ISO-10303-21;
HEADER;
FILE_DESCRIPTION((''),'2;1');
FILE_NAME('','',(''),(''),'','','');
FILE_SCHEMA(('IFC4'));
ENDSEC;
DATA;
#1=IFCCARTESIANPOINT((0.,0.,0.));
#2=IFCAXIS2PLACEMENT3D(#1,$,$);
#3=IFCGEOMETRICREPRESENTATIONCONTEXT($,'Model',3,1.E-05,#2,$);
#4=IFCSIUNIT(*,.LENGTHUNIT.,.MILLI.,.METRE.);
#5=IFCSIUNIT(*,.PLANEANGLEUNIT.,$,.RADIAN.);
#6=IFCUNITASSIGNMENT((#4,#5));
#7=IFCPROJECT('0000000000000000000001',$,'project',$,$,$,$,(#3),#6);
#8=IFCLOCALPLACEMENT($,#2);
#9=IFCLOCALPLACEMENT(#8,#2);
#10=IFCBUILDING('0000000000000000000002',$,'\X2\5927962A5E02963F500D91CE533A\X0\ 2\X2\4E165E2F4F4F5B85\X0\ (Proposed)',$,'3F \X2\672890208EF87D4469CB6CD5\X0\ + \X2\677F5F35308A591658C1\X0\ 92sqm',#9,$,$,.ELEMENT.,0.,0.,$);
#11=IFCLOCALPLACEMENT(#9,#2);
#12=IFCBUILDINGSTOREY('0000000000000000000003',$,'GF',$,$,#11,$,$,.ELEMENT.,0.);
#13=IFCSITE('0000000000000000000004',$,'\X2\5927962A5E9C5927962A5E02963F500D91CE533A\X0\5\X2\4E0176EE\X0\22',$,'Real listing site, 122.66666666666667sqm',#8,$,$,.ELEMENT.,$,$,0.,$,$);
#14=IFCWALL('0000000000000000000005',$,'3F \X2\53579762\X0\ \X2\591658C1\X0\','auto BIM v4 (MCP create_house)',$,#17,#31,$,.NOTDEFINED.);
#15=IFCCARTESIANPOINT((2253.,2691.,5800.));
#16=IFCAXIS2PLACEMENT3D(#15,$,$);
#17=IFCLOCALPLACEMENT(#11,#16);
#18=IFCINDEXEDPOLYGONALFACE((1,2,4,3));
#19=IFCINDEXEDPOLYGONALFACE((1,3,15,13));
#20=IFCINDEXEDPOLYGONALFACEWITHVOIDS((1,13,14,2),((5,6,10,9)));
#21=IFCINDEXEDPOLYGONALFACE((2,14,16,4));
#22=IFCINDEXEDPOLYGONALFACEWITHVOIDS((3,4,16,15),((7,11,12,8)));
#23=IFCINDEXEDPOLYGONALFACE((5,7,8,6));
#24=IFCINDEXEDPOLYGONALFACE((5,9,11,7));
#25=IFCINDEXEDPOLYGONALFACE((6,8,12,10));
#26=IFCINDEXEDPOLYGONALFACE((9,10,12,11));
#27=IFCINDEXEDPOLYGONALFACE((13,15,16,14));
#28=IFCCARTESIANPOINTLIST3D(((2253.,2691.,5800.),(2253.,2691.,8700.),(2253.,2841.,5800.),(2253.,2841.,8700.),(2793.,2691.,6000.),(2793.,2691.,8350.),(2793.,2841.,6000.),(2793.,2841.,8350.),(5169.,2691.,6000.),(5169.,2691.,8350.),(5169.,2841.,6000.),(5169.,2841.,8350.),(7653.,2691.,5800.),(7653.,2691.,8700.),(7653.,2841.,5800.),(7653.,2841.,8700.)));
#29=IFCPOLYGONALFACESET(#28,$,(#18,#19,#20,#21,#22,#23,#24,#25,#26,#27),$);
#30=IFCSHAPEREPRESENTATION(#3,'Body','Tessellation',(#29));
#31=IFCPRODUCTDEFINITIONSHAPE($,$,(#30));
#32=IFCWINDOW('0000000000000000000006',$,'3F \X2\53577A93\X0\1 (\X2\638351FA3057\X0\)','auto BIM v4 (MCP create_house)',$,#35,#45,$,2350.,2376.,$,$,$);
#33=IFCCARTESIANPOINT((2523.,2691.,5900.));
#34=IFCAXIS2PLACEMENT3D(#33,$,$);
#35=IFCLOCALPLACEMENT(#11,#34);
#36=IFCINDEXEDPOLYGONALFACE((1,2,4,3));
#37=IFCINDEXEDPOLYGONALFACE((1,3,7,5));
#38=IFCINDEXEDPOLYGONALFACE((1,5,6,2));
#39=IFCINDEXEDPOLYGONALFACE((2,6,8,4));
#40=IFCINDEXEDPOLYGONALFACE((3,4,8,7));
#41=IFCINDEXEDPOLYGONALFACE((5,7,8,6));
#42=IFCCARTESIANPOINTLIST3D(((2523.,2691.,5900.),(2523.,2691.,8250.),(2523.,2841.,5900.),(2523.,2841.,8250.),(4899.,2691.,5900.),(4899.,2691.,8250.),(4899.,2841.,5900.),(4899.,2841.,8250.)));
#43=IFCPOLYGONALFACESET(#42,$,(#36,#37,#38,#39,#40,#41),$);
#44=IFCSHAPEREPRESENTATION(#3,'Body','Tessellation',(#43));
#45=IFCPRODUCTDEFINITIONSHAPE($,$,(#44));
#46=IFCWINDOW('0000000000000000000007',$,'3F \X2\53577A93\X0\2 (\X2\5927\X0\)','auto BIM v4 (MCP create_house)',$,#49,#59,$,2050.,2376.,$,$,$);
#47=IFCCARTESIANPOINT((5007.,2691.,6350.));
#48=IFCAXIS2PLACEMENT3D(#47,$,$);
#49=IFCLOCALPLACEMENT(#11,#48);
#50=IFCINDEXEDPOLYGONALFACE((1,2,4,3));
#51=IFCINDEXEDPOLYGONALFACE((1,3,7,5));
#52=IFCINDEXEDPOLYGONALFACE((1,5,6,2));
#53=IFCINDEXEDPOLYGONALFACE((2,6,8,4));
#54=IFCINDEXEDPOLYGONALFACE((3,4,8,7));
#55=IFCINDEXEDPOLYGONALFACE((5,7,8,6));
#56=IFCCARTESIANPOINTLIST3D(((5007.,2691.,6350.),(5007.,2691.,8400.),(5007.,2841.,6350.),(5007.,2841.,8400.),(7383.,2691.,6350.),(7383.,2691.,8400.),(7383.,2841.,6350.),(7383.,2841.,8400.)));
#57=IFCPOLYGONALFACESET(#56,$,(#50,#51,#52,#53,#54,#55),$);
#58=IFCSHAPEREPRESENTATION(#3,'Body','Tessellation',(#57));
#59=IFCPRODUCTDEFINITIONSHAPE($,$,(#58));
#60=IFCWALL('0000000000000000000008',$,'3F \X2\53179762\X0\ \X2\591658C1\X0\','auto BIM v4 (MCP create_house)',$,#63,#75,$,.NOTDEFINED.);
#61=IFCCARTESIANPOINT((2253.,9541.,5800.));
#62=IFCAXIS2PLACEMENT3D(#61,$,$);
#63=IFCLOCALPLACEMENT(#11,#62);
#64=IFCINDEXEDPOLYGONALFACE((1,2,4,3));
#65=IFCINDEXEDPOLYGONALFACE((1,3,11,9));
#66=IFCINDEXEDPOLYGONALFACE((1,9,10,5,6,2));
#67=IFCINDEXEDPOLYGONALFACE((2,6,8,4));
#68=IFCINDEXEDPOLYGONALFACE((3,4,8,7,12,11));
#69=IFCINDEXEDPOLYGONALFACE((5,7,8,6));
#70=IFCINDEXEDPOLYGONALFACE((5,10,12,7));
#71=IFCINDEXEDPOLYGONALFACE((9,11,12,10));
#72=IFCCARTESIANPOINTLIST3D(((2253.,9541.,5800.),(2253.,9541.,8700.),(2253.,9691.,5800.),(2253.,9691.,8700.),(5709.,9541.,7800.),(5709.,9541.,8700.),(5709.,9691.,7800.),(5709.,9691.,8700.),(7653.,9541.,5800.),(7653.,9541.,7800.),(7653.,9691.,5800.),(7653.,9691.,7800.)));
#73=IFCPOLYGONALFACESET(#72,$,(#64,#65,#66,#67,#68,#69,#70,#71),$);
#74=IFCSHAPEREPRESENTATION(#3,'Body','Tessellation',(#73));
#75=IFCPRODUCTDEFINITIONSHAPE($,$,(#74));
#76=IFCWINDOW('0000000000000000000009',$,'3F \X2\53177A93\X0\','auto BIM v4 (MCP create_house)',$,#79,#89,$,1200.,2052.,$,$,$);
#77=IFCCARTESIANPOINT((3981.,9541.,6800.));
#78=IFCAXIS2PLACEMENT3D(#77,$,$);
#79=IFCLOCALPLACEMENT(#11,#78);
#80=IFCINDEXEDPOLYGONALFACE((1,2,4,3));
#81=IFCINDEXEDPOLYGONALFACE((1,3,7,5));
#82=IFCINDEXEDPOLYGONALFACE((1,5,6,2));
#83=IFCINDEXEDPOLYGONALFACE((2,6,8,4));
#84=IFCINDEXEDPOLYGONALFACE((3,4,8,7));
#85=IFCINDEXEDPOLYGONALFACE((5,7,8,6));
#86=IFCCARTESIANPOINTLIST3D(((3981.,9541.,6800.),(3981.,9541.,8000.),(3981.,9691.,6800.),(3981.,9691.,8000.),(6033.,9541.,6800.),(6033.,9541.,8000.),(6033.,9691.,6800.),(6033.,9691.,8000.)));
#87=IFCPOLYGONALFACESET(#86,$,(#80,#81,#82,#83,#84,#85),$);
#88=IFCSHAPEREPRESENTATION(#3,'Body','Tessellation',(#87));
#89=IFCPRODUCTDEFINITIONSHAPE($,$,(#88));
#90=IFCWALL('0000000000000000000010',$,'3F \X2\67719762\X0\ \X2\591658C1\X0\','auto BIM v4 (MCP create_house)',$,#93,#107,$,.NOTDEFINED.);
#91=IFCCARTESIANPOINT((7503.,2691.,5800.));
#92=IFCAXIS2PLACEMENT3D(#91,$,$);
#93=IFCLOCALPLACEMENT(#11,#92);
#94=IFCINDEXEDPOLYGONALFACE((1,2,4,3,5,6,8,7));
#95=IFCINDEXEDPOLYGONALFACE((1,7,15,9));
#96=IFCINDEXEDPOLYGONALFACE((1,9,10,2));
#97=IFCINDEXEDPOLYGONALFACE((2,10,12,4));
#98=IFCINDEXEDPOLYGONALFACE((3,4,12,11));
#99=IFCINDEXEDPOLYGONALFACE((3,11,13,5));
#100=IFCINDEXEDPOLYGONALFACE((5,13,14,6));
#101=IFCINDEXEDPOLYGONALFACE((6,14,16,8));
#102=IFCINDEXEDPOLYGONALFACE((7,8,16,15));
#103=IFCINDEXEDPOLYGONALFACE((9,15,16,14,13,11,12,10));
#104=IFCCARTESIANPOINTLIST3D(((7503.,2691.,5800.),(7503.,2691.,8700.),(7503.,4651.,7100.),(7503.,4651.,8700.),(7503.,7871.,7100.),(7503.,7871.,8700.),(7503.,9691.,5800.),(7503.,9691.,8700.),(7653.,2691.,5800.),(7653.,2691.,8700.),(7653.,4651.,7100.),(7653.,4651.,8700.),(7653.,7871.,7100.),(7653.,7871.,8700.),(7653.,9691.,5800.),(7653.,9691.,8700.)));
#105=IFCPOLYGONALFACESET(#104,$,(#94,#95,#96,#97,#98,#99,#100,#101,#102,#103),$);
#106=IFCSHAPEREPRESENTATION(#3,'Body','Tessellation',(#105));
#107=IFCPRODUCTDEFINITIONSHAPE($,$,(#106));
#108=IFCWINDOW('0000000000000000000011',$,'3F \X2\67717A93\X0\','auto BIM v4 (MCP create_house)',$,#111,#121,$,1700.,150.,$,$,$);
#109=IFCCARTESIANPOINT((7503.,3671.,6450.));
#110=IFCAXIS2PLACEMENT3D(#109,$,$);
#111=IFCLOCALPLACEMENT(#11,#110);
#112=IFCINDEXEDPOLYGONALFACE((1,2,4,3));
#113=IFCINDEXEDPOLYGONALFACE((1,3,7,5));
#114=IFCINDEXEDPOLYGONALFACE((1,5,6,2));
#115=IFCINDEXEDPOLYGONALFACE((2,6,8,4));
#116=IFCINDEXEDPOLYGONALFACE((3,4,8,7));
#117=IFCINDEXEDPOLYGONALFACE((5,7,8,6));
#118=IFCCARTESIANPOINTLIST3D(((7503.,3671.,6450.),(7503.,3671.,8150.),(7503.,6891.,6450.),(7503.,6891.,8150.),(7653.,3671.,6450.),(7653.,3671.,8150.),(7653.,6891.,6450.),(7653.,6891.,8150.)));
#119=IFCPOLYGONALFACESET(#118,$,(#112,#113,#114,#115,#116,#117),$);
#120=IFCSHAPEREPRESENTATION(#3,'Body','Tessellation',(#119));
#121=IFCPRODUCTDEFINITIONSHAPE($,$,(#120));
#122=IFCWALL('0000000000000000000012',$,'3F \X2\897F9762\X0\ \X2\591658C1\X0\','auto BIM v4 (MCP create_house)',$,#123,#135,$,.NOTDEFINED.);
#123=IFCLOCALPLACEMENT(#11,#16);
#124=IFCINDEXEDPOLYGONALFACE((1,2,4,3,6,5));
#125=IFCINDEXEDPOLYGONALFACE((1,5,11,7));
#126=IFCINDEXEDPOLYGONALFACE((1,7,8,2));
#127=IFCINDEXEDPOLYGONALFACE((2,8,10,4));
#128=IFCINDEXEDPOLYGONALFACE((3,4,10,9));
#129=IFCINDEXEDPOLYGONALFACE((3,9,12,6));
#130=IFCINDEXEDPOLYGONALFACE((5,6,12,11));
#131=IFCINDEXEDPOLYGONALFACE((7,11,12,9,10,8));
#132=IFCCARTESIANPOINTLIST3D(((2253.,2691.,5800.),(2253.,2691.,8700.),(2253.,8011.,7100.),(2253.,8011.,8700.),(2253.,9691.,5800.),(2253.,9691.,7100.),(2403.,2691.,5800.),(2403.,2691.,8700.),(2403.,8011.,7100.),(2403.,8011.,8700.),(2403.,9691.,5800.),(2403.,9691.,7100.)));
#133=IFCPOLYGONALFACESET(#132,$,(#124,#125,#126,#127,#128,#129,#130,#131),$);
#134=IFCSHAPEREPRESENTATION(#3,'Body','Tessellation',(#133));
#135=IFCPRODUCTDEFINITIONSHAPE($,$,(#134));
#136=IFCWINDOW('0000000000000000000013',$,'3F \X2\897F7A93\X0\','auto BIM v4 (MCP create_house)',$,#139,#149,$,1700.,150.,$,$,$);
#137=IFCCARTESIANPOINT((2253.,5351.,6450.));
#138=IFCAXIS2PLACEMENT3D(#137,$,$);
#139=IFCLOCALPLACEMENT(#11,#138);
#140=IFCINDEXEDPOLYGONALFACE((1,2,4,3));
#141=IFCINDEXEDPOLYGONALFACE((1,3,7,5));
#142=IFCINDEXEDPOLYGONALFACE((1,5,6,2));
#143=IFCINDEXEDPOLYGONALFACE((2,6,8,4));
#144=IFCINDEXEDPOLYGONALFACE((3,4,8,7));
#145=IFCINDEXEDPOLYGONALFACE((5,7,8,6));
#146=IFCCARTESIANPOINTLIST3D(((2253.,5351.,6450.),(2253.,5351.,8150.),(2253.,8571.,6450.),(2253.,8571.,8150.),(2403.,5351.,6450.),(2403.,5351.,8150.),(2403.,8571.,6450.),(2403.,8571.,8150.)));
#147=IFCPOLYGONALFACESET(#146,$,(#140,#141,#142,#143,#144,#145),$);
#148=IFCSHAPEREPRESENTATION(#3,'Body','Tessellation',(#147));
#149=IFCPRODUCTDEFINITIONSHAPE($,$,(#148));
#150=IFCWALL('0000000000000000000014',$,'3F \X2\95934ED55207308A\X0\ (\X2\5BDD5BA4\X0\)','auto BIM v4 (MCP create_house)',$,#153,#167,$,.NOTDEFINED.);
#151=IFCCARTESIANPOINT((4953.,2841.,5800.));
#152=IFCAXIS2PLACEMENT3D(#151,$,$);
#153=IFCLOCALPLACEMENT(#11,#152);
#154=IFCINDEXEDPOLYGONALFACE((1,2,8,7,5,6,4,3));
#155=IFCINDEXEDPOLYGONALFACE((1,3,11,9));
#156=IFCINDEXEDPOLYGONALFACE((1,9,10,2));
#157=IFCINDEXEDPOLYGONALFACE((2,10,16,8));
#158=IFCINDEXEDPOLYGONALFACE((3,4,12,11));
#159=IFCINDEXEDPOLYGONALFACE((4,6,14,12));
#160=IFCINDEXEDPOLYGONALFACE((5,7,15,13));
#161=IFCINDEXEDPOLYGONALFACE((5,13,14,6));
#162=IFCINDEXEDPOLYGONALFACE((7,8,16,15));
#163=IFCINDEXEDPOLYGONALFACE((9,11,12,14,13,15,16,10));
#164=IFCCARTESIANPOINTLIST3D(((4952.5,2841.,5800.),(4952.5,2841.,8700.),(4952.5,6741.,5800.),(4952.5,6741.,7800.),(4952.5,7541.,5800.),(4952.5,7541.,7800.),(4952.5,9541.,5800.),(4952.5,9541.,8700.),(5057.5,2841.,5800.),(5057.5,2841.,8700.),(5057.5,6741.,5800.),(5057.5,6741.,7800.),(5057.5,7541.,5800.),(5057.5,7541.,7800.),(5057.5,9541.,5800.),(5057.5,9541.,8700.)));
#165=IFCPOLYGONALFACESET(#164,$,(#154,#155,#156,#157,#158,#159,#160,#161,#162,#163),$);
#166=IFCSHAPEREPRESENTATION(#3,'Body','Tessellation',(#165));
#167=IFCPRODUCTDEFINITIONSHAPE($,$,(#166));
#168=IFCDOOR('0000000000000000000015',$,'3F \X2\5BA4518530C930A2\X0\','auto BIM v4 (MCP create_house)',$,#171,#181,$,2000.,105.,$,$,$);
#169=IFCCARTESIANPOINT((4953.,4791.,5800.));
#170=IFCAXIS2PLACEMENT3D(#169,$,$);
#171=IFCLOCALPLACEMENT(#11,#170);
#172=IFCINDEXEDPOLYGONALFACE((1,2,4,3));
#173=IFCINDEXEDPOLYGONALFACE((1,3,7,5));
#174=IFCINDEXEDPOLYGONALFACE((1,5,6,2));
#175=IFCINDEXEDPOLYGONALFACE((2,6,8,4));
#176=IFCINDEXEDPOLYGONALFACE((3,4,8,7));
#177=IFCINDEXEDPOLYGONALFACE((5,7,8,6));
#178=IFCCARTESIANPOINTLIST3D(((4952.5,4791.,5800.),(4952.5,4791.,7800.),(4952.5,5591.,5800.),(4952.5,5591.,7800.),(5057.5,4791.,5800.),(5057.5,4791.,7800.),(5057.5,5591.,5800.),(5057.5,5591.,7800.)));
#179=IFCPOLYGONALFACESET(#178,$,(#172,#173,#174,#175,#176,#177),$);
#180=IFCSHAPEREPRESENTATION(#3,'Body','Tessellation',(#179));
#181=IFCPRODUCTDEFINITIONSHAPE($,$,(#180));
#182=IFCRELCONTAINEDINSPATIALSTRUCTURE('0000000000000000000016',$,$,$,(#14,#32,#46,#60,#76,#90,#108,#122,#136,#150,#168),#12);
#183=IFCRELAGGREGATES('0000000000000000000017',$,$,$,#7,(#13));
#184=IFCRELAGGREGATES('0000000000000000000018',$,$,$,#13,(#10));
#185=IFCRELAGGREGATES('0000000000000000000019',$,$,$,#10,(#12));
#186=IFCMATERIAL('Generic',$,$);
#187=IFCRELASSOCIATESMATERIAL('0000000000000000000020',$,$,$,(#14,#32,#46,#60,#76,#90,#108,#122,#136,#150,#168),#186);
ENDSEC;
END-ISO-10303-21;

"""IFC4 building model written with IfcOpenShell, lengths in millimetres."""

from ifc_helpers import new_model, si_unit, frame, frame_2d, origin, place, context, project, spatial, rectangle, extrude, material, element, fill, save


model = new_model("IFC4")

# Units and contexts
model_context = context("Model", 3, precision=1e-05, world=origin())
ifc_project = project(units=[si_unit("LENGTHUNIT", "METRE", prefix="MILLI"), si_unit("PLANEANGLEUNIT", "RADIAN")], contexts=[model_context])

# Site, building, storey
site_placement = place(None, origin())
site = spatial("IfcSite", under=ifc_project, at=site_placement, Name="大阪府大阪市阿倍野区5丁目22", ObjectType="Real listing site, 122.66666666666667sqm", CompositionType="ELEMENT", RefElevation=0.0)
building_placement = place(site_placement, origin())
building = spatial("IfcBuilding", under=site, at=building_placement, Name="大阪市阿倍野区 2世帯住宅 (Proposed)", ObjectType="3F 木造軸組構法 + 板張り外壁 92sqm", CompositionType="ELEMENT", ElevationOfRefHeight=0.0, ElevationOfTerrain=0.0)
storey_placement = place(building_placement, origin())
storey = spatial("IfcBuildingStorey", under=building, at=storey_placement, Name="GF", CompositionType="ELEMENT", Elevation=0.0)

# Shared definitions
ifc_material = material(Name="Generic")

# Wall, openings, windows
wall_1_placement = place(storey_placement, frame((2253.0, 2691.0, 5800.0)))
wall_1 = element("IfcWall", 1, at=wall_1_placement, inside=storey, material=ifc_material, Name="3F 南面 外壁", Description="auto BIM v4 (MCP create_house)", PredefinedType="NOTDEFINED", context=model_context, shape_type="SweptSolid", body=[
    extrude(rectangle(XDim=5400.0, YDim=150.0, at=frame_2d((2700.0, 75.0))), frame((2253.0, 2691.0, 5800.0)), (0.0, 0.0, 1.0), 2900.0),
])
opening_1_placement = place(storey_placement, frame((2523.0, 2691.0, 5900.0)))
opening_1 = element("IfcOpeningElement", 2, at=opening_1_placement, cuts=wall_1, PredefinedType="NOTDEFINED", context=model_context, shape_type="SweptSolid", body=[
    extrude(rectangle(XDim=2376.0, YDim=150.0, at=frame_2d((1188.0, 75.0))), frame((2523.0, 2691.0, 5900.0)), (0.0, 0.0, 1.0), 2350.0),
])
opening_2_placement = place(storey_placement, frame((5007.0, 2691.0, 6350.0)))
opening_2 = element("IfcOpeningElement", 3, at=opening_2_placement, cuts=wall_1, PredefinedType="NOTDEFINED", context=model_context, shape_type="SweptSolid", body=[
    extrude(rectangle(XDim=2376.0, YDim=150.0, at=frame_2d((1188.0, 75.0))), frame((5007.0, 2691.0, 6350.0)), (0.0, 0.0, 1.0), 2050.0),
])
window_1_placement = place(storey_placement, frame((2523.0, 2691.0, 5900.0)))
window_1 = element("IfcWindow", 4, at=window_1_placement, inside=storey, material=ifc_material, Name="3F 南窓1 (掃出し)", Description="auto BIM v4 (MCP create_house)", OverallHeight=2350.0, OverallWidth=2376.0, context=model_context, shape_type="SweptSolid", body=[
    extrude(rectangle(XDim=2376.0, YDim=150.0, at=frame_2d((1188.0, 75.0))), frame((2523.0, 2691.0, 5900.0)), (0.0, 0.0, 1.0), 2350.0),
])
fill(opening_1, window_1)
window_2_placement = place(storey_placement, frame((5007.0, 2691.0, 6350.0)))
window_2 = element("IfcWindow", 5, at=window_2_placement, inside=storey, material=ifc_material, Name="3F 南窓2 (大)", Description="auto BIM v4 (MCP create_house)", OverallHeight=2050.0, OverallWidth=2376.0, context=model_context, shape_type="SweptSolid", body=[
    extrude(rectangle(XDim=2376.0, YDim=150.0, at=frame_2d((1188.0, 75.0))), frame((5007.0, 2691.0, 6350.0)), (0.0, 0.0, 1.0), 2050.0),
])
fill(opening_2, window_2)

# Walls, openings, windows
wall_2_placement = place(storey_placement, frame((2253.0, 9541.0, 5800.0)))
wall_2 = element("IfcWall", 6, at=wall_2_placement, inside=storey, material=ifc_material, Name="3F 北面 外壁", Description="auto BIM v4 (MCP create_house)", PredefinedType="NOTDEFINED", context=model_context, shape_type="SweptSolid", body=[
    extrude(rectangle(XDim=5400.0, YDim=150.0, at=frame_2d((2700.0, 75.0))), frame((2253.0, 9541.0, 5800.0)), (0.0, 0.0, 1.0), 2900.0),
])
opening_3_placement = place(storey_placement, frame((3981.0, 9541.0, 6800.0)))
opening_3 = element("IfcOpeningElement", 7, at=opening_3_placement, cuts=wall_2, PredefinedType="NOTDEFINED", context=model_context, shape_type="SweptSolid", body=[
    extrude(rectangle(XDim=2052.0, YDim=150.0, at=frame_2d((1026.0, 75.0))), frame((3981.0, 9541.0, 6800.0)), (0.0, 0.0, 1.0), 1200.0),
])
window_3_placement = place(storey_placement, frame((3981.0, 9541.0, 6800.0)))
window_3 = element("IfcWindow", 8, at=window_3_placement, inside=storey, material=ifc_material, Name="3F 北窓", Description="auto BIM v4 (MCP create_house)", OverallHeight=1200.0, OverallWidth=2052.0, context=model_context, shape_type="SweptSolid", body=[
    extrude(rectangle(XDim=2052.0, YDim=150.0, at=frame_2d((1026.0, 75.0))), frame((3981.0, 9541.0, 6800.0)), (0.0, 0.0, 1.0), 1200.0),
])
fill(opening_3, window_3)
wall_3_placement = place(storey_placement, frame((7503.0, 2691.0, 5800.0)))
wall_3 = element("IfcWall", 9, at=wall_3_placement, inside=storey, material=ifc_material, Name="3F 東面 外壁", Description="auto BIM v4 (MCP create_house)", PredefinedType="NOTDEFINED", context=model_context, shape_type="SweptSolid", body=[
    extrude(rectangle(XDim=150.0, YDim=7000.0, at=frame_2d((75.0, 3500.0))), frame((7503.0, 2691.0, 5800.0)), (0.0, 0.0, 1.0), 2900.0),
])
opening_4_placement = place(storey_placement, frame((7503.0, 3671.0, 6450.0)))
opening_4 = element("IfcOpeningElement", 10, at=opening_4_placement, cuts=wall_3, PredefinedType="NOTDEFINED", context=model_context, shape_type="SweptSolid", body=[
    extrude(rectangle(XDim=150.0, YDim=3220.0, at=frame_2d((75.0, 1610.0))), frame((7503.0, 3671.0, 6450.0)), (0.0, 0.0, 1.0), 1700.0),
])
window_4_placement = place(storey_placement, frame((7503.0, 3671.0, 6450.0)))
window_4 = element("IfcWindow", 11, at=window_4_placement, inside=storey, material=ifc_material, Name="3F 東窓", Description="auto BIM v4 (MCP create_house)", OverallHeight=1700.0, OverallWidth=150.0, context=model_context, shape_type="SweptSolid", body=[
    extrude(rectangle(XDim=150.0, YDim=3220.0, at=frame_2d((75.0, 1610.0))), frame((7503.0, 3671.0, 6450.0)), (0.0, 0.0, 1.0), 1700.0),
])
fill(opening_4, window_4)
wall_4_placement = place(storey_placement, frame((2253.0, 2691.0, 5800.0)))
wall_4 = element("IfcWall", 12, at=wall_4_placement, inside=storey, material=ifc_material, Name="3F 西面 外壁", Description="auto BIM v4 (MCP create_house)", PredefinedType="NOTDEFINED", context=model_context, shape_type="SweptSolid", body=[
    extrude(rectangle(XDim=150.0, YDim=7000.0, at=frame_2d((75.0, 3500.0))), frame((2253.0, 2691.0, 5800.0)), (0.0, 0.0, 1.0), 2900.0),
])
opening_5_placement = place(storey_placement, frame((2253.0, 5351.0, 6450.0)))
opening_5 = element("IfcOpeningElement", 13, at=opening_5_placement, cuts=wall_4, PredefinedType="NOTDEFINED", context=model_context, shape_type="SweptSolid", body=[
    extrude(rectangle(XDim=150.0, YDim=3220.0, at=frame_2d((75.0, 1610.0))), frame((2253.0, 5351.0, 6450.0)), (0.0, 0.0, 1.0), 1700.0),
])
window_5_placement = place(storey_placement, frame((2253.0, 5351.0, 6450.0)))
window_5 = element("IfcWindow", 14, at=window_5_placement, inside=storey, material=ifc_material, Name="3F 西窓", Description="auto BIM v4 (MCP create_house)", OverallHeight=1700.0, OverallWidth=150.0, context=model_context, shape_type="SweptSolid", body=[
    extrude(rectangle(XDim=150.0, YDim=3220.0, at=frame_2d((75.0, 1610.0))), frame((2253.0, 5351.0, 6450.0)), (0.0, 0.0, 1.0), 1700.0),
])
fill(opening_5, window_5)

# Wall, opening, door
wall_5_placement = place(storey_placement, frame((4953.0, 2841.0, 5800.0)))
wall_5 = element("IfcWall", 15, at=wall_5_placement, inside=storey, material=ifc_material, Name="3F 間仕切り (寝室)", Description="auto BIM v4 (MCP create_house)", PredefinedType="NOTDEFINED", context=model_context, shape_type="SweptSolid", body=[
    extrude(rectangle(XDim=105.0, YDim=6700.0, at=frame_2d((52.0, 3350.0))), frame((4953.0, 2841.0, 5800.0)), (0.0, 0.0, 1.0), 2900.0),
])
opening_6_placement = place(storey_placement, frame((4953.0, 4791.0, 5800.0)))
opening_6 = element("IfcOpeningElement", 16, at=opening_6_placement, cuts=wall_5, PredefinedType="NOTDEFINED", context=model_context, shape_type="SweptSolid", body=[
    extrude(rectangle(XDim=105.0, YDim=800.0, at=frame_2d((52.0, 400.0))), frame((4953.0, 4791.0, 5800.0)), (0.0, 0.0, 1.0), 2000.0),
])
door_1_placement = place(storey_placement, frame((4953.0, 4791.0, 5800.0)))
door_1 = element("IfcDoor", 17, at=door_1_placement, inside=storey, material=ifc_material, Name="3F 室内ドア", Description="auto BIM v4 (MCP create_house)", OverallHeight=2000.0, OverallWidth=105.0, context=model_context, shape_type="SweptSolid", body=[
    extrude(rectangle(XDim=105.0, YDim=800.0, at=frame_2d((52.0, 400.0))), frame((4953.0, 4791.0, 5800.0)), (0.0, 0.0, 1.0), 2000.0),
])
fill(opening_6, door_1)

save(model, "model.ifc")
